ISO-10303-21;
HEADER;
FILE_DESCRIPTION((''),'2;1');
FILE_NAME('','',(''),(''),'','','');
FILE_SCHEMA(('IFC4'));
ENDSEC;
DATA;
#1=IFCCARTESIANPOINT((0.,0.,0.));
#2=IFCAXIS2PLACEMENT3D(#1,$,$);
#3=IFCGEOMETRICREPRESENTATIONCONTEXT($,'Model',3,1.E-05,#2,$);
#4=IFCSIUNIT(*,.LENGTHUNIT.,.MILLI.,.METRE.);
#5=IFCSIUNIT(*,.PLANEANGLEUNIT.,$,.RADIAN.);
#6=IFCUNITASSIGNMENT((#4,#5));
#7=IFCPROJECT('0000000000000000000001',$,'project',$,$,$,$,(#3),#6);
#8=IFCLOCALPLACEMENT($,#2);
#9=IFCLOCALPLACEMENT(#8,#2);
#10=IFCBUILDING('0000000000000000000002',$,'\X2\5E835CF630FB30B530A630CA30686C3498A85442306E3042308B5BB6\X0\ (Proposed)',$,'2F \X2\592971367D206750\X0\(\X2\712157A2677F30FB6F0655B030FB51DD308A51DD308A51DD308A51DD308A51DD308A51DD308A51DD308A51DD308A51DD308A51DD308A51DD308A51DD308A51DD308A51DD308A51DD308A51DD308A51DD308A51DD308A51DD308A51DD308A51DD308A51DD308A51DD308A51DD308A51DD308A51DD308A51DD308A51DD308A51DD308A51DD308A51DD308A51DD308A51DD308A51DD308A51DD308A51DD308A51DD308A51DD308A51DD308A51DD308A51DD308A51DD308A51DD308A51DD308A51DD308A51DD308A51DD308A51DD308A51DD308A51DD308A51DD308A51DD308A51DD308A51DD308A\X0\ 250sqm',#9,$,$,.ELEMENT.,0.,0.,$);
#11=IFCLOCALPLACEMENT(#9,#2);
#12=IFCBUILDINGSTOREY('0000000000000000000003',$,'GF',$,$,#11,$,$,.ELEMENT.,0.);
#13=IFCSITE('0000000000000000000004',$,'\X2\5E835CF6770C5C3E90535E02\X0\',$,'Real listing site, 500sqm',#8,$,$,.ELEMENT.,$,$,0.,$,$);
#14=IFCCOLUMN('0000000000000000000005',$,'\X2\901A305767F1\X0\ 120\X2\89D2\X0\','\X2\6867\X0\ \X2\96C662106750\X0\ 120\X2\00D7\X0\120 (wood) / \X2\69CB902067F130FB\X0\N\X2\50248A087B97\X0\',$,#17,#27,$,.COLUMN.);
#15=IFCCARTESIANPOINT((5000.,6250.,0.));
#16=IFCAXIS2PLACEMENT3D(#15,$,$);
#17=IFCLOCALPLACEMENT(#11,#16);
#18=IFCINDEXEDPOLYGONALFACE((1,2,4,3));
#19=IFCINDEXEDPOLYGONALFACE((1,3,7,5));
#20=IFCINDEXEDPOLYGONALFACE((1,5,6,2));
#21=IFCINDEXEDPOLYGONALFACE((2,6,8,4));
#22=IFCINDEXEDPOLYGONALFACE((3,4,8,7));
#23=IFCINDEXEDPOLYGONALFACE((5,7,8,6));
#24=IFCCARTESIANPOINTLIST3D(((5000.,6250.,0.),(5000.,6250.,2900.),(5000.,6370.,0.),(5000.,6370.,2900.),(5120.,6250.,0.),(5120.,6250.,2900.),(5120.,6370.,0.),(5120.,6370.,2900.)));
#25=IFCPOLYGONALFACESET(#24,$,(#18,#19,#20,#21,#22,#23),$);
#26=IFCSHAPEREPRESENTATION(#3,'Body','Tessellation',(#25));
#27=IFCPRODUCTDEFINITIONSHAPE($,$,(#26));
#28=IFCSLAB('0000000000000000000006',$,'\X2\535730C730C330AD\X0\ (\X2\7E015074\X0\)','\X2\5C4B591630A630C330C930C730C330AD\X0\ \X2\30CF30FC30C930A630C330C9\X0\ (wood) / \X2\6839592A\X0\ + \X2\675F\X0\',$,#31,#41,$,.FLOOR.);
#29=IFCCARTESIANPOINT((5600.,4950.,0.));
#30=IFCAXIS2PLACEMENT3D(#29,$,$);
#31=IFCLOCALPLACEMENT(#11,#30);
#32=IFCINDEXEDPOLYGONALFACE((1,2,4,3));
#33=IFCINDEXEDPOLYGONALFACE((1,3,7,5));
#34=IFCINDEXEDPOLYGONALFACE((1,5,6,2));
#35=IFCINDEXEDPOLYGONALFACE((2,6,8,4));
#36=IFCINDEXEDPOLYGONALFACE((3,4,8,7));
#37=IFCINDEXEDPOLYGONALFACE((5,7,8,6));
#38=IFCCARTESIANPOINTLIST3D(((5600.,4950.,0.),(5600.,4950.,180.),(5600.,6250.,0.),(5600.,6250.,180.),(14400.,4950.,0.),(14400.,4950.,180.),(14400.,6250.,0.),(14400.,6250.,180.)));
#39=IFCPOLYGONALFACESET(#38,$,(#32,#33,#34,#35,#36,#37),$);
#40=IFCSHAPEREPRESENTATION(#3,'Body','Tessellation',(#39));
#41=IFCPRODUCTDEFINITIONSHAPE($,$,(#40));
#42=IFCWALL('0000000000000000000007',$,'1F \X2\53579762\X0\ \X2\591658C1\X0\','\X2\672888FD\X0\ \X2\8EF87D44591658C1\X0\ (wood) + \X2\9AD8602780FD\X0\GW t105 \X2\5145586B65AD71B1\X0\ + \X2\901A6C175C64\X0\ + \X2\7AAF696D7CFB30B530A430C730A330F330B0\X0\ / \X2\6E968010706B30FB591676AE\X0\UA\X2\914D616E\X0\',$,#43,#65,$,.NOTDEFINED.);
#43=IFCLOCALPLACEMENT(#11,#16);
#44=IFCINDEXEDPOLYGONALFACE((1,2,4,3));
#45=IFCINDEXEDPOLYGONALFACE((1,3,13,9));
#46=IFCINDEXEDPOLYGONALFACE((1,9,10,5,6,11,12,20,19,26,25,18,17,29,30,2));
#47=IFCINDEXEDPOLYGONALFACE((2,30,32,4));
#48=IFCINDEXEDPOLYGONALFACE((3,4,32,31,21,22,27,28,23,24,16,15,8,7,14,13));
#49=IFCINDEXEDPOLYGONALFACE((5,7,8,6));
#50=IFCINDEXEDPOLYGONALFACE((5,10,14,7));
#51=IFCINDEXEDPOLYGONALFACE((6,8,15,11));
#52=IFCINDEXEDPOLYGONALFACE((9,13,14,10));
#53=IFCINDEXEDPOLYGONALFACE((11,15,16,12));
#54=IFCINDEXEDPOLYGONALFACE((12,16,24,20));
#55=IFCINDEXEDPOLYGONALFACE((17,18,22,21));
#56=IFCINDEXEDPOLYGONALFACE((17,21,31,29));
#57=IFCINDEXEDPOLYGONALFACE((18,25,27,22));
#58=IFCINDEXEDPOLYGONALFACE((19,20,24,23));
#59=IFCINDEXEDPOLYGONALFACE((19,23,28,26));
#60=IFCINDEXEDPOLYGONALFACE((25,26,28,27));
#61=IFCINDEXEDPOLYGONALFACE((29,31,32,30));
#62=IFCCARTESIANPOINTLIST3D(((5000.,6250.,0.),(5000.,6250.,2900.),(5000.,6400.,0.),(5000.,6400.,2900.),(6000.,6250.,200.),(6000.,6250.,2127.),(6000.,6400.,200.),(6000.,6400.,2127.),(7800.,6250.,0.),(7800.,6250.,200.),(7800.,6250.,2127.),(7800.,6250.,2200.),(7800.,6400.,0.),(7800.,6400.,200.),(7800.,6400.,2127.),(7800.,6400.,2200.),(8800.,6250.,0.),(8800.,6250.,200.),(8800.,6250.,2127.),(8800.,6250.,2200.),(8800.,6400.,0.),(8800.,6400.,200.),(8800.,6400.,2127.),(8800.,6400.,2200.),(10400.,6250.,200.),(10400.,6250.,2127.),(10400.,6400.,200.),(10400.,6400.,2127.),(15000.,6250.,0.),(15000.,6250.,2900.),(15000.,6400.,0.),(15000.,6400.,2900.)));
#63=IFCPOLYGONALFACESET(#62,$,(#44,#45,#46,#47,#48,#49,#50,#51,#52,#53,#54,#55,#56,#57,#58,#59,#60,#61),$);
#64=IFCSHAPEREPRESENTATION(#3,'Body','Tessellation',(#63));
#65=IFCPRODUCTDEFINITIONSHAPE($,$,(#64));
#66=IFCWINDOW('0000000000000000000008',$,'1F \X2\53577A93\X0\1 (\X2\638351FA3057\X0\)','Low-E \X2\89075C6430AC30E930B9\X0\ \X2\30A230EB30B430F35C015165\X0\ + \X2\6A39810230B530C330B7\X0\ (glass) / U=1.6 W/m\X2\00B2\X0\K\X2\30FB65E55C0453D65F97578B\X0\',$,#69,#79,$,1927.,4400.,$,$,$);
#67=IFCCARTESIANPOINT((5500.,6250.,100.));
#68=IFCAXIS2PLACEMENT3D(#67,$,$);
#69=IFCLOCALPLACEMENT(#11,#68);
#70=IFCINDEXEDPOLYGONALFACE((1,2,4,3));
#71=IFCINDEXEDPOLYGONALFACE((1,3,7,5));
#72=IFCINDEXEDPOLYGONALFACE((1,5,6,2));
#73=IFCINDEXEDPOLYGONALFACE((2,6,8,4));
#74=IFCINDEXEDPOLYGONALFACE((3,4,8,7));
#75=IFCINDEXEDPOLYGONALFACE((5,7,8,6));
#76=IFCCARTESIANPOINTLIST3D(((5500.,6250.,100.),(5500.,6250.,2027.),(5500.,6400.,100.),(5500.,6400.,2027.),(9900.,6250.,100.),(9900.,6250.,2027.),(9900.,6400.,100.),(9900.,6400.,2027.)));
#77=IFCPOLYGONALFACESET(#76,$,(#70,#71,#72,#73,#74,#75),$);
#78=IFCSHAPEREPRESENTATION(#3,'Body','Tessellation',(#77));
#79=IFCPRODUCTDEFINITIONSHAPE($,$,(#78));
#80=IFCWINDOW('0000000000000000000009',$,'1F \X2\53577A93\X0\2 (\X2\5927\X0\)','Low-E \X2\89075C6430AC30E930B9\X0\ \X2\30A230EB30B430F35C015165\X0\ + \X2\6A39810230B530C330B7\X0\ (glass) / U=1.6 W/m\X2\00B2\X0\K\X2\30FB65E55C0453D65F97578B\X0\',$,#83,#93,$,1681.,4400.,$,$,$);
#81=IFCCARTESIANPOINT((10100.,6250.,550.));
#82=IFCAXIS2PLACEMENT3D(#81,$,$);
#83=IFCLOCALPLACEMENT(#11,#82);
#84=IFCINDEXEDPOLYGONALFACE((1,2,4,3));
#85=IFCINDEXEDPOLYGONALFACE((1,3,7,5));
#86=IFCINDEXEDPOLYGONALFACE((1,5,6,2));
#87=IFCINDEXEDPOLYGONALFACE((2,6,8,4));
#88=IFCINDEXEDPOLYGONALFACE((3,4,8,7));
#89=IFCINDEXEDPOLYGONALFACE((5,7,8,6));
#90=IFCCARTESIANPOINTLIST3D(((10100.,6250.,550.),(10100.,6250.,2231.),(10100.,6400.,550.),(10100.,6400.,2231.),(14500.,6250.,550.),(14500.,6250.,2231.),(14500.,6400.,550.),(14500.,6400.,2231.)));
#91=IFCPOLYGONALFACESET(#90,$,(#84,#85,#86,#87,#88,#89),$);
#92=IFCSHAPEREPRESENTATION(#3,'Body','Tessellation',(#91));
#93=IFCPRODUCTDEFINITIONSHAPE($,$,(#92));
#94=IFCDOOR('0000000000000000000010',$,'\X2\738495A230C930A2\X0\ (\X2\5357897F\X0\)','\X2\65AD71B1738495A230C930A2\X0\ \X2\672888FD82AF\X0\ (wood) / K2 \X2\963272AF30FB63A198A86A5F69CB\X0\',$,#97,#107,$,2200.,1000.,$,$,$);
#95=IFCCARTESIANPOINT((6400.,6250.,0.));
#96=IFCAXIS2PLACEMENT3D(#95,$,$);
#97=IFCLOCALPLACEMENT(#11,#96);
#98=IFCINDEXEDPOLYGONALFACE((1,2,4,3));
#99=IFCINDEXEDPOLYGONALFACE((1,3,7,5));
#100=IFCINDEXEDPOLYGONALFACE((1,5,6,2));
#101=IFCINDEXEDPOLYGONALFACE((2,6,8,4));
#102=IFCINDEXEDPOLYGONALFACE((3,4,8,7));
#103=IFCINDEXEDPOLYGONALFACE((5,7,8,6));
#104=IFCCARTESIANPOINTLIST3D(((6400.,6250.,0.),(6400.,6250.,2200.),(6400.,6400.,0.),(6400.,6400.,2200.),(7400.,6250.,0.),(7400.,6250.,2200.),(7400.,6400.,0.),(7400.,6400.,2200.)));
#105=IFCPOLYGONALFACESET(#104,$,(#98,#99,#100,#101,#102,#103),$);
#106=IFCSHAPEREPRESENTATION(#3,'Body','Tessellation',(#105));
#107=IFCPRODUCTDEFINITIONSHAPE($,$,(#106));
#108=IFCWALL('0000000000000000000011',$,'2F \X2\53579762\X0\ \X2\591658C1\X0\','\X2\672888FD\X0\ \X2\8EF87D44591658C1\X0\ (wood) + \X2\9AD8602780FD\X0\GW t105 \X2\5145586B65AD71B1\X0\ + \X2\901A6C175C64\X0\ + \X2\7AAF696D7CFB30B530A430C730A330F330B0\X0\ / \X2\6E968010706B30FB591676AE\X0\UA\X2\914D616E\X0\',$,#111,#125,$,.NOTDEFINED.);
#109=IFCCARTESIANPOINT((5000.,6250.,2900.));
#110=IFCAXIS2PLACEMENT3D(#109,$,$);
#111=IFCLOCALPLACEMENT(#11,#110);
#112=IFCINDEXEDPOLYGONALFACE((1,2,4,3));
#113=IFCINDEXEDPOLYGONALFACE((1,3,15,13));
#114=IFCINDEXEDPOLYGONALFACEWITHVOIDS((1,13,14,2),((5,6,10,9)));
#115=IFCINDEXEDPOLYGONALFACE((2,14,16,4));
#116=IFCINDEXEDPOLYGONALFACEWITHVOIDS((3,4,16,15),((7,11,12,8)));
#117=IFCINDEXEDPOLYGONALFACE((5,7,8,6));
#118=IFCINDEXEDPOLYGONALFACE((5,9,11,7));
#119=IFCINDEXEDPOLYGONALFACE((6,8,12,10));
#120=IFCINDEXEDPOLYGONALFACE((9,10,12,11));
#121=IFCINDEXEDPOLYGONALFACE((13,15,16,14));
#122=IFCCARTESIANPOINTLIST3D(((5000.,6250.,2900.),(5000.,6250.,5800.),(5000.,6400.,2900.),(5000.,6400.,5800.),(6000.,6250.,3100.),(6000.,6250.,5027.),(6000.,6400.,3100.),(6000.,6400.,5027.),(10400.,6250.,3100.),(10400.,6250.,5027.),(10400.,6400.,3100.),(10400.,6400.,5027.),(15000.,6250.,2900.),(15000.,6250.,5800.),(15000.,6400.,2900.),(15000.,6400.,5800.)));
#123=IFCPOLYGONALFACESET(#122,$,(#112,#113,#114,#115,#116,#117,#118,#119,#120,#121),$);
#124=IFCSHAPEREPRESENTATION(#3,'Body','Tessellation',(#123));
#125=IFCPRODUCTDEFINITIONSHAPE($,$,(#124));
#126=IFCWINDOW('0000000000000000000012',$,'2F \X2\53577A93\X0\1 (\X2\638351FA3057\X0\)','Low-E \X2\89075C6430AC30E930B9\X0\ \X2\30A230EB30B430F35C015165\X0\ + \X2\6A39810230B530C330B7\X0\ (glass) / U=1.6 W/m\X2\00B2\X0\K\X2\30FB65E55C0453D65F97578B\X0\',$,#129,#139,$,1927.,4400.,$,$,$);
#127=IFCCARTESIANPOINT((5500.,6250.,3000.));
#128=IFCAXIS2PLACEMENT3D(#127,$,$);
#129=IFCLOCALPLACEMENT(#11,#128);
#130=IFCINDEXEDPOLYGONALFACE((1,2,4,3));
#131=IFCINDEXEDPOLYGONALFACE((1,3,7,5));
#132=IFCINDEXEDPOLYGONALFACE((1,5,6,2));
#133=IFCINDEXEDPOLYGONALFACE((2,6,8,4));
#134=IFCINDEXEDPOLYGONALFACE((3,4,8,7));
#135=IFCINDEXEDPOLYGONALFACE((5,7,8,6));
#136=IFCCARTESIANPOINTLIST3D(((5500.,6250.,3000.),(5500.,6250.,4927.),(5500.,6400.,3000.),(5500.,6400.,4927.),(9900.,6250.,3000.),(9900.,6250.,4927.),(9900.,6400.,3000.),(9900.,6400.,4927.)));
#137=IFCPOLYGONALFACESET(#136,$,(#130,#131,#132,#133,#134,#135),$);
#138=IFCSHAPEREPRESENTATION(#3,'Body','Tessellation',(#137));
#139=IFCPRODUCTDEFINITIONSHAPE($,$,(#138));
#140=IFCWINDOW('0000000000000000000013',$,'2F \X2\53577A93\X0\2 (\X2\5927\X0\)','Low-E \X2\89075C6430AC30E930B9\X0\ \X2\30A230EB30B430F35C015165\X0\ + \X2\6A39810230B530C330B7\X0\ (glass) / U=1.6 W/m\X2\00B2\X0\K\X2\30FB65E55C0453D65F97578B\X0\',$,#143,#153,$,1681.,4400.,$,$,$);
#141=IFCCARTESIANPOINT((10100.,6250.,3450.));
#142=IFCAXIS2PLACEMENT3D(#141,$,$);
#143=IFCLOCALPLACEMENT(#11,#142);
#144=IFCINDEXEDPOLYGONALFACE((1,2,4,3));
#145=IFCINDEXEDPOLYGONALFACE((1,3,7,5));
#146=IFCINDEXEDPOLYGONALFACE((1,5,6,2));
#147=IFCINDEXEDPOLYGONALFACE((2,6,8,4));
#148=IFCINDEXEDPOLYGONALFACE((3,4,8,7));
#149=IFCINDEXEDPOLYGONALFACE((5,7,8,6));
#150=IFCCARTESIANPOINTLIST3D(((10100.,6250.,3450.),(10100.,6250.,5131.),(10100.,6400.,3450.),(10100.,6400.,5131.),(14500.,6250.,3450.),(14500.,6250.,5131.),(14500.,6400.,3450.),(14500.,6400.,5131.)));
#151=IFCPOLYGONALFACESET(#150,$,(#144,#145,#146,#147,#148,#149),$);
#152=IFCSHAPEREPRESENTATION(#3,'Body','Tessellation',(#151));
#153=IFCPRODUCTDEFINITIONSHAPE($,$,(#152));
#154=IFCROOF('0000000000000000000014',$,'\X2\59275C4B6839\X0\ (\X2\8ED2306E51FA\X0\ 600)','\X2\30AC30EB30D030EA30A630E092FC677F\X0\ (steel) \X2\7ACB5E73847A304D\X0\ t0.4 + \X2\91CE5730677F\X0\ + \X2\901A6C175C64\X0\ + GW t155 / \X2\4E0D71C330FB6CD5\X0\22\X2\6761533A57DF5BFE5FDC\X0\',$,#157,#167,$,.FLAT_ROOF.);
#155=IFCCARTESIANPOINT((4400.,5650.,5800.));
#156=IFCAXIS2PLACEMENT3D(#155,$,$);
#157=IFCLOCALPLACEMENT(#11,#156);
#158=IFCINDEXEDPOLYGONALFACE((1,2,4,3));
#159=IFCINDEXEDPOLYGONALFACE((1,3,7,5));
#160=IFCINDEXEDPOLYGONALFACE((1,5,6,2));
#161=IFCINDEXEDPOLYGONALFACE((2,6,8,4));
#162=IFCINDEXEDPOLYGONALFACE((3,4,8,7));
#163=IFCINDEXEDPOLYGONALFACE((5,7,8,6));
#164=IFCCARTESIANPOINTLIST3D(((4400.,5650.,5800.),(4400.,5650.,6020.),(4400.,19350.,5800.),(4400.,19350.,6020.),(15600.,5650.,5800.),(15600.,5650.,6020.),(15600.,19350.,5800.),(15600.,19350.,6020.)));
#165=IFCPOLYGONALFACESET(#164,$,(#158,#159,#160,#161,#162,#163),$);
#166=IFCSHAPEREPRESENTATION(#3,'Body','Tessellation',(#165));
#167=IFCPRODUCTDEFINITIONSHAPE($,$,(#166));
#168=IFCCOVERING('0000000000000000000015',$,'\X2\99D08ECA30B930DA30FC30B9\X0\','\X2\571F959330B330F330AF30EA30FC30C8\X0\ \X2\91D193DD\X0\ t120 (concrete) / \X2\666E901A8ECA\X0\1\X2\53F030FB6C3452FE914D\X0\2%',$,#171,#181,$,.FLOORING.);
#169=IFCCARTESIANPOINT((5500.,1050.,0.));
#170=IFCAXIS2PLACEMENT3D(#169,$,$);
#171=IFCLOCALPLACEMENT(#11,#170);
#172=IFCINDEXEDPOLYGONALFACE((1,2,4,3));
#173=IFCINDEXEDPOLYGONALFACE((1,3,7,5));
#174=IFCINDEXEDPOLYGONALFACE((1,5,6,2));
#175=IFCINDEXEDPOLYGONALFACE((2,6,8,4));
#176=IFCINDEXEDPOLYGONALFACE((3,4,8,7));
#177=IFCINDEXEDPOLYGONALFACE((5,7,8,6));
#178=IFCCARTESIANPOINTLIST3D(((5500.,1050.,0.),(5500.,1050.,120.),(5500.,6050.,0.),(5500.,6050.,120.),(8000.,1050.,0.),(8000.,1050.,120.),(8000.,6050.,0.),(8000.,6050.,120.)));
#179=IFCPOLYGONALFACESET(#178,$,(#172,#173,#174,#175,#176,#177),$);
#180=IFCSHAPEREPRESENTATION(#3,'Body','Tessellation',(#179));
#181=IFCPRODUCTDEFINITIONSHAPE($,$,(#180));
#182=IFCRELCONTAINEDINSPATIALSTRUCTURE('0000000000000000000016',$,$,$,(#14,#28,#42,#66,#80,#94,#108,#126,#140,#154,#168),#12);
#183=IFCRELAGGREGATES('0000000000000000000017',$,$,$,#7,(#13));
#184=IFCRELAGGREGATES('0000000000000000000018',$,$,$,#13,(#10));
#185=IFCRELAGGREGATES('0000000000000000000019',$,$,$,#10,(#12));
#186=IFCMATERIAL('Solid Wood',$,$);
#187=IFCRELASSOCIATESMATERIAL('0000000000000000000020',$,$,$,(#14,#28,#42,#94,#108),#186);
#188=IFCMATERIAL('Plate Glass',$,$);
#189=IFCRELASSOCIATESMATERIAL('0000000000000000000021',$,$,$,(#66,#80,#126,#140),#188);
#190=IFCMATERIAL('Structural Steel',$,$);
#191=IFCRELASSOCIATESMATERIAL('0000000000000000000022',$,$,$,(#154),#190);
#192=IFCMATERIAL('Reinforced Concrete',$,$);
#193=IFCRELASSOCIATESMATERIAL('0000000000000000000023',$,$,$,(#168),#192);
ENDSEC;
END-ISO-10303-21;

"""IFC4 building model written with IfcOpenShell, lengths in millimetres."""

from ifc_helpers import new_model, si_unit, frame, frame_2d, origin, place, context, project, spatial, rectangle, extrude, material, element, fill, save


model = new_model("IFC4")

# Units and contexts
model_context = context("Model", 3, precision=1e-05, world=origin())
ifc_project = project(units=[si_unit("LENGTHUNIT", "METRE", prefix="MILLI"), si_unit("PLANEANGLEUNIT", "RADIAN")], contexts=[model_context])

# Site, building, storey
site_placement = place(None, origin())
site = spatial("IfcSite", under=ifc_project, at=site_placement, Name="広島県尾道市", ObjectType="Real listing site, 500sqm", CompositionType="ELEMENT", RefElevation=0.0)
building_placement = place(site_placement, origin())
building = spatial("IfcBuilding", under=site, at=building_placement, Name="広島・サウナと水風呂のある家 (Proposed)", ObjectType="2F 天然素材(無垢板・漆喰・凝り凝り凝り凝り凝り凝り凝り凝り凝り凝り凝り凝り凝り凝り凝り凝り凝り凝り凝り凝り凝り凝り凝り凝り凝り凝り凝り凝り凝り凝り凝り凝り凝り凝り凝り凝り凝り凝り凝り凝り凝り凝り凝り凝り凝り凝り凝り凝り凝り凝り凝り凝り凝り凝り 250sqm", CompositionType="ELEMENT", ElevationOfRefHeight=0.0, ElevationOfTerrain=0.0)
storey_placement = place(building_placement, origin())
storey = spatial("IfcBuildingStorey", under=building, at=storey_placement, Name="GF", CompositionType="ELEMENT", Elevation=0.0)

# Column
ifc_material_1 = material(Name="Solid Wood")
column_placement = place(storey_placement, frame((5000.0, 6250.0, 0.0)))
element("IfcColumn", 1, at=column_placement, inside=storey, material=ifc_material_1, Name="通し柱 120角", Description="桧 集成材 120×120 (wood) / 構造柱・N値計算", PredefinedType="COLUMN", context=model_context, shape_type="SweptSolid", body=[
    extrude(rectangle(XDim=120.0, YDim=120.0, at=frame_2d((60.0, 60.0))), frame((5000.0, 6250.0, 0.0)), (0.0, 0.0, 1.0), 2900.0),
])

# Slab
ifc_material_2 = material(Name="Reinforced Concrete")
slab_1_placement = place(storey_placement, frame((5600.0, 4950.0, 0.0)))
element("IfcSlab", 2, at=slab_1_placement, inside=storey, material=ifc_material_1, Name="南デッキ (縁側)", Description="屋外ウッドデッキ ハードウッド (wood) / 根太 + 束", PredefinedType="FLOOR", context=model_context, shape_type="SweptSolid", body=[
    extrude(rectangle(XDim=8800.0, YDim=1300.0, at=frame_2d((4400.0, 650.0))), frame((5600.0, 4950.0, 0.0)), (0.0, 0.0, 1.0), 180.0),
])

# Wall, openings, windows, door
wall_1_placement = place(storey_placement, frame((5000.0, 6250.0, 0.0)))
wall_1 = element("IfcWall", 3, at=wall_1_placement, inside=storey, material=ifc_material_1, Name="1F 南面 外壁", Description="木製 軸組外壁 (wood) + 高性能GW t105 充填断熱 + 通気層 + 窯業系サイディング / 準耐火・外皮UA配慮", PredefinedType="NOTDEFINED", context=model_context, shape_type="SweptSolid", body=[
    extrude(rectangle(XDim=10000.0, YDim=150.0, at=frame_2d((5000.0, 75.0))), frame((5000.0, 6250.0, 0.0)), (0.0, 0.0, 1.0), 2900.0),
])
opening_1_placement = place(storey_placement, frame((5500.0, 6250.0, 100.0)))
opening_1 = element("IfcOpeningElement", 4, at=opening_1_placement, cuts=wall_1, PredefinedType="NOTDEFINED", context=model_context, shape_type="SweptSolid", body=[
    extrude(rectangle(XDim=4400.0, YDim=150.0, at=frame_2d((2200.0, 75.0))), frame((5500.0, 6250.0, 100.0)), (0.0, 0.0, 1.0), 1927.0),
])
opening_2_placement = place(storey_placement, frame((10100.0, 6250.0, 550.0)))
opening_2 = element("IfcOpeningElement", 5, at=opening_2_placement, cuts=wall_1, PredefinedType="NOTDEFINED", context=model_context, shape_type="SweptSolid", body=[
    extrude(rectangle(XDim=4400.0, YDim=150.0, at=frame_2d((2200.0, 75.0))), frame((10100.0, 6250.0, 550.0)), (0.0, 0.0, 1.0), 1681.0),
])
opening_3_placement = place(storey_placement, frame((6400.0, 6250.0, 0.0)))
opening_3 = element("IfcOpeningElement", 6, at=opening_3_placement, cuts=wall_1, PredefinedType="NOTDEFINED", context=model_context, shape_type="SweptSolid", body=[
    extrude(rectangle(XDim=1000.0, YDim=150.0, at=frame_2d((500.0, 75.0))), frame((6400.0, 6250.0, 0.0)), (0.0, 0.0, 1.0), 2200.0),
])
ifc_material_3 = material(Name="Plate Glass")
window_1_placement = place(storey_placement, frame((5500.0, 6250.0, 100.0)))
window_1 = element("IfcWindow", 7, at=window_1_placement, inside=storey, material=ifc_material_3, Name="1F 南窓1 (掃出し)", Description="Low-E 複層ガラス アルゴン封入 + 樹脂サッシ (glass) / U=1.6 W/m²K・日射取得型", OverallHeight=1927.0, OverallWidth=4400.0, context=model_context, shape_type="SweptSolid", body=[
    extrude(rectangle(XDim=4400.0, YDim=150.0, at=frame_2d((2200.0, 75.0))), frame((5500.0, 6250.0, 100.0)), (0.0, 0.0, 1.0), 1927.0),
])
fill(opening_1, window_1)
window_2_placement = place(storey_placement, frame((10100.0, 6250.0, 550.0)))
window_2 = element("IfcWindow", 8, at=window_2_placement, inside=storey, material=ifc_material_3, Name="1F 南窓2 (大)", Description="Low-E 複層ガラス アルゴン封入 + 樹脂サッシ (glass) / U=1.6 W/m²K・日射取得型", OverallHeight=1681.0, OverallWidth=4400.0, context=model_context, shape_type="SweptSolid", body=[
    extrude(rectangle(XDim=4400.0, YDim=150.0, at=frame_2d((2200.0, 75.0))), frame((10100.0, 6250.0, 550.0)), (0.0, 0.0, 1.0), 1681.0),
])
fill(opening_2, window_2)
door_placement = place(storey_placement, frame((6400.0, 6250.0, 0.0)))
door = element("IfcDoor", 9, at=door_placement, inside=storey, material=ifc_material_1, Name="玄関ドア (南西)", Description="断熱玄関ドア 木製芯 (wood) / K2 防犯・採風機構", OverallHeight=2200.0, OverallWidth=1000.0, context=model_context, shape_type="SweptSolid", body=[
    extrude(rectangle(XDim=1000.0, YDim=150.0, at=frame_2d((500.0, 75.0))), frame((6400.0, 6250.0, 0.0)), (0.0, 0.0, 1.0), 2200.0),
])
fill(opening_3, door)

# Wall, openings, windows
wall_2_placement = place(storey_placement, frame((5000.0, 6250.0, 2900.0)))
wall_2 = element("IfcWall", 10, at=wall_2_placement, inside=storey, material=ifc_material_1, Name="2F 南面 外壁", Description="木製 軸組外壁 (wood) + 高性能GW t105 充填断熱 + 通気層 + 窯業系サイディング / 準耐火・外皮UA配慮", PredefinedType="NOTDEFINED", context=model_context, shape_type="SweptSolid", body=[
    extrude(rectangle(XDim=10000.0, YDim=150.0, at=frame_2d((5000.0, 75.0))), frame((5000.0, 6250.0, 2900.0)), (0.0, 0.0, 1.0), 2900.0),
])
opening_4_placement = place(storey_placement, frame((5500.0, 6250.0, 3000.0)))
opening_4 = element("IfcOpeningElement", 11, at=opening_4_placement, cuts=wall_2, PredefinedType="NOTDEFINED", context=model_context, shape_type="SweptSolid", body=[
    extrude(rectangle(XDim=4400.0, YDim=150.0, at=frame_2d((2200.0, 75.0))), frame((5500.0, 6250.0, 3000.0)), (0.0, 0.0, 1.0), 1927.0),
])
opening_5_placement = place(storey_placement, frame((10100.0, 6250.0, 3450.0)))
opening_5 = element("IfcOpeningElement", 12, at=opening_5_placement, cuts=wall_2, PredefinedType="NOTDEFINED", context=model_context, shape_type="SweptSolid", body=[
    extrude(rectangle(XDim=4400.0, YDim=150.0, at=frame_2d((2200.0, 75.0))), frame((10100.0, 6250.0, 3450.0)), (0.0, 0.0, 1.0), 1681.0),
])
window_3_placement = place(storey_placement, frame((5500.0, 6250.0, 3000.0)))
window_3 = element("IfcWindow", 13, at=window_3_placement, inside=storey, material=ifc_material_3, Name="2F 南窓1 (掃出し)", Description="Low-E 複層ガラス アルゴン封入 + 樹脂サッシ (glass) / U=1.6 W/m²K・日射取得型", OverallHeight=1927.0, OverallWidth=4400.0, context=model_context, shape_type="SweptSolid", body=[
    extrude(rectangle(XDim=4400.0, YDim=150.0, at=frame_2d((2200.0, 75.0))), frame((5500.0, 6250.0, 3000.0)), (0.0, 0.0, 1.0), 1927.0),
])
fill(opening_4, window_3)
window_4_placement = place(storey_placement, frame((10100.0, 6250.0, 3450.0)))
window_4 = element("IfcWindow", 14, at=window_4_placement, inside=storey, material=ifc_material_3, Name="2F 南窓2 (大)", Description="Low-E 複層ガラス アルゴン封入 + 樹脂サッシ (glass) / U=1.6 W/m²K・日射取得型", OverallHeight=1681.0, OverallWidth=4400.0, context=model_context, shape_type="SweptSolid", body=[
    extrude(rectangle(XDim=4400.0, YDim=150.0, at=frame_2d((2200.0, 75.0))), frame((10100.0, 6250.0, 3450.0)), (0.0, 0.0, 1.0), 1681.0),
])
fill(opening_5, window_4)

# Roof
ifc_material_4 = material(Name="Structural Steel")
roof_placement = place(storey_placement, frame((4400.0, 5650.0, 5800.0)))
element("IfcRoof", 15, at=roof_placement, inside=storey, material=ifc_material_4, Name="大屋根 (軒の出 600)", Description="ガルバリウム鋼板 (steel) 立平葺き t0.4 + 野地板 + 通気層 + GW t155 / 不燃・法22条区域対応", PredefinedType="FLAT_ROOF", context=model_context, shape_type="SweptSolid", body=[
    extrude(rectangle(XDim=11200.0, YDim=13700.0, at=frame_2d((5600.0, 6850.0))), frame((4400.0, 5650.0, 5800.0)), (0.0, 0.0, 1.0), 220.0),
])

# Covering
covering_placement = place(storey_placement, frame((5500.0, 1050.0, 0.0)))
element("IfcCovering", 16, at=covering_placement, inside=storey, material=ifc_material_2, Name="駐車スペース", Description="土間コンクリート 金鏝 t120 (concrete) / 普通車1台・水勾配2%", PredefinedType="FLOORING", context=model_context, shape_type="SweptSolid", body=[
    extrude(rectangle(XDim=2500.0, YDim=5000.0, at=frame_2d((1250.0, 2500.0))), frame((5500.0, 1050.0, 0.0)), (0.0, 0.0, 1.0), 120.0),
])

save(model, "model.ifc")
